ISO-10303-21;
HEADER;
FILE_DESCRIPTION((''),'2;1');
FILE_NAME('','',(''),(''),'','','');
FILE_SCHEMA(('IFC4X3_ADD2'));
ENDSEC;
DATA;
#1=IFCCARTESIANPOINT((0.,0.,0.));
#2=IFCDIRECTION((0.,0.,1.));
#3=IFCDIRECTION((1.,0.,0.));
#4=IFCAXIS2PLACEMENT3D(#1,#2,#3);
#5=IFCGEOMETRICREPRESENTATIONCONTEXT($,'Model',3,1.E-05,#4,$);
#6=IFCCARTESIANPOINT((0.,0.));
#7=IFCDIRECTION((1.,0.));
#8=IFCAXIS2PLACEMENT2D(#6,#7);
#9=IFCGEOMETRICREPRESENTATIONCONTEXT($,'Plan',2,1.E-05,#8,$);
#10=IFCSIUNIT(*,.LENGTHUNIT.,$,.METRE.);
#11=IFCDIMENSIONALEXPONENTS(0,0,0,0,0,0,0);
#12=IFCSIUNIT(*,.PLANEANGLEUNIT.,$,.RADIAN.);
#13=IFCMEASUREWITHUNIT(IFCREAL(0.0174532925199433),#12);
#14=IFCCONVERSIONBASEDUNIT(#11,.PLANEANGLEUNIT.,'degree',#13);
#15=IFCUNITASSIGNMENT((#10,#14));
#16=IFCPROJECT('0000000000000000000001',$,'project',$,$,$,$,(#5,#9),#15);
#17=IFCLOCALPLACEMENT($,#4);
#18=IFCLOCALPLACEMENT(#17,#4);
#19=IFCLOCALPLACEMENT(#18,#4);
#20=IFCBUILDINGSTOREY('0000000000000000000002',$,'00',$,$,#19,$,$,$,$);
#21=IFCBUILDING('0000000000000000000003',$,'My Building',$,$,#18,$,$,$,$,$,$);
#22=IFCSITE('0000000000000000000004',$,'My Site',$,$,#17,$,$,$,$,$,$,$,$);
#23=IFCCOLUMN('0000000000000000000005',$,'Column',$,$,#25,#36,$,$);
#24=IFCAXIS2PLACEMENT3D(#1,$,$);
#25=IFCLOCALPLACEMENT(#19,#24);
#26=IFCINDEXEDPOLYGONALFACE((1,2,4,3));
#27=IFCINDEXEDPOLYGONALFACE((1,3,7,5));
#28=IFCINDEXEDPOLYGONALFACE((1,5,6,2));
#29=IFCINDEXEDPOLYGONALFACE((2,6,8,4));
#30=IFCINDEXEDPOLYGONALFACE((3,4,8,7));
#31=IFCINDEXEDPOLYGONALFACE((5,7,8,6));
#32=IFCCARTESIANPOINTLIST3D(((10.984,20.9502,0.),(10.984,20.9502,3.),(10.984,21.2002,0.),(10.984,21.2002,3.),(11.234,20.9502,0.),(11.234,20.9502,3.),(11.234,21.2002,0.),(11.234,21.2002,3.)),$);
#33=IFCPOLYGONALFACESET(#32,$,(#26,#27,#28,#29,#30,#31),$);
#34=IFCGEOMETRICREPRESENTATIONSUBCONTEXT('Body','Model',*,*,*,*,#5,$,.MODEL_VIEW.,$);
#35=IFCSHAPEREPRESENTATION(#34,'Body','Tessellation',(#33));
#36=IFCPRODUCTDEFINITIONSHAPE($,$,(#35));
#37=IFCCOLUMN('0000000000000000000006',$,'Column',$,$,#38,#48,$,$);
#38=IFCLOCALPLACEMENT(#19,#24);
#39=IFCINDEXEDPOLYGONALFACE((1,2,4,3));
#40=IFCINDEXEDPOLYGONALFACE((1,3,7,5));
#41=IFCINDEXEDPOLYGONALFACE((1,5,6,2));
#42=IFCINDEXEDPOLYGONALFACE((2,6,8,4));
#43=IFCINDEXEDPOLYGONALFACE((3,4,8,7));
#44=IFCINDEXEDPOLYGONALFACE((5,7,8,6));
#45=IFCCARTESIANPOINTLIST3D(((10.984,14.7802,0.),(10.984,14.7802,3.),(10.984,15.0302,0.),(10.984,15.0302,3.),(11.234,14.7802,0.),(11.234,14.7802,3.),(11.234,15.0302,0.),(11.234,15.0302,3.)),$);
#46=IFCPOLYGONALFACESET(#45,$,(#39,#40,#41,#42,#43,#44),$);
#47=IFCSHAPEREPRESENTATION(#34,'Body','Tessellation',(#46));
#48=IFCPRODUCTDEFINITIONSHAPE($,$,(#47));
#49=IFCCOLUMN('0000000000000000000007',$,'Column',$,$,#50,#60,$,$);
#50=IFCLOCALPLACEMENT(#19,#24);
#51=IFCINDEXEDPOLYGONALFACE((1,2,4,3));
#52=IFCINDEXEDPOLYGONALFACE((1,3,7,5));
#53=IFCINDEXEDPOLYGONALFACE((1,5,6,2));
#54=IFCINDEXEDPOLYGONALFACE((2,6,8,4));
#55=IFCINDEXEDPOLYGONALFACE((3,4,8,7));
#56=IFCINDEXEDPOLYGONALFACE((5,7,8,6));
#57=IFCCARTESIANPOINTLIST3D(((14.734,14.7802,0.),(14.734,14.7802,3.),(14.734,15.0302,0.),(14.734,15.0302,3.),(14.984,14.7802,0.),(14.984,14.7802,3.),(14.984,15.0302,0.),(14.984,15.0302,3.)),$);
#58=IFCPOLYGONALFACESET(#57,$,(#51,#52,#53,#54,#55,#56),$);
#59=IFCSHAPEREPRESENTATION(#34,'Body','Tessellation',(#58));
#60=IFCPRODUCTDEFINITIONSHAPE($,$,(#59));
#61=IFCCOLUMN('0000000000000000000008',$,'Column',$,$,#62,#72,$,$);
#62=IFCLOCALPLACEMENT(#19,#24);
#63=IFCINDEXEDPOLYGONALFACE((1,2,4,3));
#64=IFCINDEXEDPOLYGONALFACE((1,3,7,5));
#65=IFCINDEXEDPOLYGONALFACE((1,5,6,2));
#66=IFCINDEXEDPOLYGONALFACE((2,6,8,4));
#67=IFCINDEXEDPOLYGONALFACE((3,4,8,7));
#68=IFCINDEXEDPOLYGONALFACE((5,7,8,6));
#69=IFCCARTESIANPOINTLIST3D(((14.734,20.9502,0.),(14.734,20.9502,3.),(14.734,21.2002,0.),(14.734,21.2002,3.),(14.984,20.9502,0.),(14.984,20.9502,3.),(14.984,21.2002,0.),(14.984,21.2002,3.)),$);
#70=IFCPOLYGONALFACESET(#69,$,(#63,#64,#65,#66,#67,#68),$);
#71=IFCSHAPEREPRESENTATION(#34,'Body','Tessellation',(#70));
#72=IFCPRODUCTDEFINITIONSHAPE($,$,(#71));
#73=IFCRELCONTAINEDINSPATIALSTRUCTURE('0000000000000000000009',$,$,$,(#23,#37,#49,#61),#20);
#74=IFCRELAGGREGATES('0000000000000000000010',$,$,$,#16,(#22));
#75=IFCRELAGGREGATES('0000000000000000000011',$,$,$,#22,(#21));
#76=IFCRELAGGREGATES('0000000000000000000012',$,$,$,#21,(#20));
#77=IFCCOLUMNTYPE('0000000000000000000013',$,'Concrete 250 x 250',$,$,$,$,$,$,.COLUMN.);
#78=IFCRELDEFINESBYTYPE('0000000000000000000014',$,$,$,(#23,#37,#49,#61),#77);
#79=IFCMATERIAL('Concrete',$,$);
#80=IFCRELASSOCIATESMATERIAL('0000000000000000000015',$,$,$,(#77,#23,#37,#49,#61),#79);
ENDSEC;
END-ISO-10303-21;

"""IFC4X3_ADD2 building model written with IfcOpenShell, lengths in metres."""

from ifc_helpers import new_model, entity, si_unit, converted_unit, frame, origin_with_axes, origin_2d_with_axis, place, context, subcontext, project, spatial, rectangle, extrude, material, material_profile, profile_set, profile_usage, type_object, element, save


model = new_model("IFC4X3_ADD2")

# Units and contexts
model_context = context("Model", 3, precision=1e-05, world=origin_with_axes())
plan_context = context("Plan", 2, precision=1e-05, world=origin_2d_with_axis())
body_context = subcontext(model_context, "Body", "Model", "MODEL_VIEW")
ifc_project = project(units=[si_unit("LENGTHUNIT", "METRE"), converted_unit("PLANEANGLEUNIT", "degree", entity("IfcReal", 0.0174532925199433), si_unit("PLANEANGLEUNIT", "RADIAN"), dimensions=[0, 0, 0, 0, 0, 0, 0])], contexts=[model_context, plan_context])

# Site, building, storey
site_placement = place(None, origin_with_axes())
site = spatial("IfcSite", under=ifc_project, at=site_placement, Name="My Site")
building_placement = place(site_placement, origin_with_axes())
building = spatial("IfcBuilding", under=site, at=building_placement, Name="My Building")
storey_placement = place(building_placement, origin_with_axes())
storey = spatial("IfcBuildingStorey", under=building, at=storey_placement, Name="00")

# Columns
ifc_material = material(Name="Concrete")
ifc_material_profile = material_profile(ifc_material, rectangle(XDim=0.25, YDim=0.25))
ifc_profile_set = profile_set([ifc_material_profile])
ifc_profile_usage_1 = profile_usage(ifc_profile_set, cardinal=5)
column_type = type_object("IfcColumnType", Name="Concrete 250 x 250", PredefinedType="COLUMN", material=ifc_profile_set)
column_1_placement = place(storey_placement, frame((11.109, 21.0752, 0.0), z_axis=(0.0, 0.0, 1.0), x_axis=(1.0, 0.0, 0.0)))
element("IfcColumn", 1, at=column_1_placement, inside=storey, type_object=column_type, material=ifc_profile_usage_1, Name="Column", context=body_context, shape_type="SweptSolid", body=[
    extrude(rectangle(XDim=0.25, YDim=0.25), origin_with_axes(), (0.0, 0.0, 1.0), 3.0),
])
ifc_profile_usage_2 = profile_usage(ifc_profile_set, cardinal=5)
column_2_placement = place(storey_placement, frame((11.109, 14.9052, 0.0), z_axis=(0.0, 0.0, 1.0), x_axis=(1.0, 0.0, 0.0)))
element("IfcColumn", 2, at=column_2_placement, inside=storey, type_object=column_type, material=ifc_profile_usage_2, Name="Column", context=body_context, shape_type="SweptSolid", body=[
    extrude(rectangle(XDim=0.25, YDim=0.25), origin_with_axes(), (0.0, 0.0, 1.0), 3.0),
])
ifc_profile_usage_3 = profile_usage(ifc_profile_set, cardinal=5)
column_3_placement = place(storey_placement, frame((14.859, 14.9052, 0.0), z_axis=(0.0, 0.0, 1.0), x_axis=(1.0, 0.0, 0.0)))
element("IfcColumn", 3, at=column_3_placement, inside=storey, type_object=column_type, material=ifc_profile_usage_3, Name="Column", context=body_context, shape_type="SweptSolid", body=[
    extrude(rectangle(XDim=0.25, YDim=0.25), origin_with_axes(), (0.0, 0.0, 1.0), 3.0),
])
ifc_profile_usage_4 = profile_usage(ifc_profile_set, cardinal=5)
column_4_placement = place(storey_placement, frame((14.859, 21.0752, 0.0), z_axis=(0.0, 0.0, 1.0), x_axis=(1.0, 0.0, 0.0)))
element("IfcColumn", 4, at=column_4_placement, inside=storey, type_object=column_type, material=ifc_profile_usage_4, Name="Column", context=body_context, shape_type="SweptSolid", body=[
    extrude(rectangle(XDim=0.25, YDim=0.25), origin_with_axes(), (0.0, 0.0, 1.0), 3.0),
])

save(model, "model.ifc")
